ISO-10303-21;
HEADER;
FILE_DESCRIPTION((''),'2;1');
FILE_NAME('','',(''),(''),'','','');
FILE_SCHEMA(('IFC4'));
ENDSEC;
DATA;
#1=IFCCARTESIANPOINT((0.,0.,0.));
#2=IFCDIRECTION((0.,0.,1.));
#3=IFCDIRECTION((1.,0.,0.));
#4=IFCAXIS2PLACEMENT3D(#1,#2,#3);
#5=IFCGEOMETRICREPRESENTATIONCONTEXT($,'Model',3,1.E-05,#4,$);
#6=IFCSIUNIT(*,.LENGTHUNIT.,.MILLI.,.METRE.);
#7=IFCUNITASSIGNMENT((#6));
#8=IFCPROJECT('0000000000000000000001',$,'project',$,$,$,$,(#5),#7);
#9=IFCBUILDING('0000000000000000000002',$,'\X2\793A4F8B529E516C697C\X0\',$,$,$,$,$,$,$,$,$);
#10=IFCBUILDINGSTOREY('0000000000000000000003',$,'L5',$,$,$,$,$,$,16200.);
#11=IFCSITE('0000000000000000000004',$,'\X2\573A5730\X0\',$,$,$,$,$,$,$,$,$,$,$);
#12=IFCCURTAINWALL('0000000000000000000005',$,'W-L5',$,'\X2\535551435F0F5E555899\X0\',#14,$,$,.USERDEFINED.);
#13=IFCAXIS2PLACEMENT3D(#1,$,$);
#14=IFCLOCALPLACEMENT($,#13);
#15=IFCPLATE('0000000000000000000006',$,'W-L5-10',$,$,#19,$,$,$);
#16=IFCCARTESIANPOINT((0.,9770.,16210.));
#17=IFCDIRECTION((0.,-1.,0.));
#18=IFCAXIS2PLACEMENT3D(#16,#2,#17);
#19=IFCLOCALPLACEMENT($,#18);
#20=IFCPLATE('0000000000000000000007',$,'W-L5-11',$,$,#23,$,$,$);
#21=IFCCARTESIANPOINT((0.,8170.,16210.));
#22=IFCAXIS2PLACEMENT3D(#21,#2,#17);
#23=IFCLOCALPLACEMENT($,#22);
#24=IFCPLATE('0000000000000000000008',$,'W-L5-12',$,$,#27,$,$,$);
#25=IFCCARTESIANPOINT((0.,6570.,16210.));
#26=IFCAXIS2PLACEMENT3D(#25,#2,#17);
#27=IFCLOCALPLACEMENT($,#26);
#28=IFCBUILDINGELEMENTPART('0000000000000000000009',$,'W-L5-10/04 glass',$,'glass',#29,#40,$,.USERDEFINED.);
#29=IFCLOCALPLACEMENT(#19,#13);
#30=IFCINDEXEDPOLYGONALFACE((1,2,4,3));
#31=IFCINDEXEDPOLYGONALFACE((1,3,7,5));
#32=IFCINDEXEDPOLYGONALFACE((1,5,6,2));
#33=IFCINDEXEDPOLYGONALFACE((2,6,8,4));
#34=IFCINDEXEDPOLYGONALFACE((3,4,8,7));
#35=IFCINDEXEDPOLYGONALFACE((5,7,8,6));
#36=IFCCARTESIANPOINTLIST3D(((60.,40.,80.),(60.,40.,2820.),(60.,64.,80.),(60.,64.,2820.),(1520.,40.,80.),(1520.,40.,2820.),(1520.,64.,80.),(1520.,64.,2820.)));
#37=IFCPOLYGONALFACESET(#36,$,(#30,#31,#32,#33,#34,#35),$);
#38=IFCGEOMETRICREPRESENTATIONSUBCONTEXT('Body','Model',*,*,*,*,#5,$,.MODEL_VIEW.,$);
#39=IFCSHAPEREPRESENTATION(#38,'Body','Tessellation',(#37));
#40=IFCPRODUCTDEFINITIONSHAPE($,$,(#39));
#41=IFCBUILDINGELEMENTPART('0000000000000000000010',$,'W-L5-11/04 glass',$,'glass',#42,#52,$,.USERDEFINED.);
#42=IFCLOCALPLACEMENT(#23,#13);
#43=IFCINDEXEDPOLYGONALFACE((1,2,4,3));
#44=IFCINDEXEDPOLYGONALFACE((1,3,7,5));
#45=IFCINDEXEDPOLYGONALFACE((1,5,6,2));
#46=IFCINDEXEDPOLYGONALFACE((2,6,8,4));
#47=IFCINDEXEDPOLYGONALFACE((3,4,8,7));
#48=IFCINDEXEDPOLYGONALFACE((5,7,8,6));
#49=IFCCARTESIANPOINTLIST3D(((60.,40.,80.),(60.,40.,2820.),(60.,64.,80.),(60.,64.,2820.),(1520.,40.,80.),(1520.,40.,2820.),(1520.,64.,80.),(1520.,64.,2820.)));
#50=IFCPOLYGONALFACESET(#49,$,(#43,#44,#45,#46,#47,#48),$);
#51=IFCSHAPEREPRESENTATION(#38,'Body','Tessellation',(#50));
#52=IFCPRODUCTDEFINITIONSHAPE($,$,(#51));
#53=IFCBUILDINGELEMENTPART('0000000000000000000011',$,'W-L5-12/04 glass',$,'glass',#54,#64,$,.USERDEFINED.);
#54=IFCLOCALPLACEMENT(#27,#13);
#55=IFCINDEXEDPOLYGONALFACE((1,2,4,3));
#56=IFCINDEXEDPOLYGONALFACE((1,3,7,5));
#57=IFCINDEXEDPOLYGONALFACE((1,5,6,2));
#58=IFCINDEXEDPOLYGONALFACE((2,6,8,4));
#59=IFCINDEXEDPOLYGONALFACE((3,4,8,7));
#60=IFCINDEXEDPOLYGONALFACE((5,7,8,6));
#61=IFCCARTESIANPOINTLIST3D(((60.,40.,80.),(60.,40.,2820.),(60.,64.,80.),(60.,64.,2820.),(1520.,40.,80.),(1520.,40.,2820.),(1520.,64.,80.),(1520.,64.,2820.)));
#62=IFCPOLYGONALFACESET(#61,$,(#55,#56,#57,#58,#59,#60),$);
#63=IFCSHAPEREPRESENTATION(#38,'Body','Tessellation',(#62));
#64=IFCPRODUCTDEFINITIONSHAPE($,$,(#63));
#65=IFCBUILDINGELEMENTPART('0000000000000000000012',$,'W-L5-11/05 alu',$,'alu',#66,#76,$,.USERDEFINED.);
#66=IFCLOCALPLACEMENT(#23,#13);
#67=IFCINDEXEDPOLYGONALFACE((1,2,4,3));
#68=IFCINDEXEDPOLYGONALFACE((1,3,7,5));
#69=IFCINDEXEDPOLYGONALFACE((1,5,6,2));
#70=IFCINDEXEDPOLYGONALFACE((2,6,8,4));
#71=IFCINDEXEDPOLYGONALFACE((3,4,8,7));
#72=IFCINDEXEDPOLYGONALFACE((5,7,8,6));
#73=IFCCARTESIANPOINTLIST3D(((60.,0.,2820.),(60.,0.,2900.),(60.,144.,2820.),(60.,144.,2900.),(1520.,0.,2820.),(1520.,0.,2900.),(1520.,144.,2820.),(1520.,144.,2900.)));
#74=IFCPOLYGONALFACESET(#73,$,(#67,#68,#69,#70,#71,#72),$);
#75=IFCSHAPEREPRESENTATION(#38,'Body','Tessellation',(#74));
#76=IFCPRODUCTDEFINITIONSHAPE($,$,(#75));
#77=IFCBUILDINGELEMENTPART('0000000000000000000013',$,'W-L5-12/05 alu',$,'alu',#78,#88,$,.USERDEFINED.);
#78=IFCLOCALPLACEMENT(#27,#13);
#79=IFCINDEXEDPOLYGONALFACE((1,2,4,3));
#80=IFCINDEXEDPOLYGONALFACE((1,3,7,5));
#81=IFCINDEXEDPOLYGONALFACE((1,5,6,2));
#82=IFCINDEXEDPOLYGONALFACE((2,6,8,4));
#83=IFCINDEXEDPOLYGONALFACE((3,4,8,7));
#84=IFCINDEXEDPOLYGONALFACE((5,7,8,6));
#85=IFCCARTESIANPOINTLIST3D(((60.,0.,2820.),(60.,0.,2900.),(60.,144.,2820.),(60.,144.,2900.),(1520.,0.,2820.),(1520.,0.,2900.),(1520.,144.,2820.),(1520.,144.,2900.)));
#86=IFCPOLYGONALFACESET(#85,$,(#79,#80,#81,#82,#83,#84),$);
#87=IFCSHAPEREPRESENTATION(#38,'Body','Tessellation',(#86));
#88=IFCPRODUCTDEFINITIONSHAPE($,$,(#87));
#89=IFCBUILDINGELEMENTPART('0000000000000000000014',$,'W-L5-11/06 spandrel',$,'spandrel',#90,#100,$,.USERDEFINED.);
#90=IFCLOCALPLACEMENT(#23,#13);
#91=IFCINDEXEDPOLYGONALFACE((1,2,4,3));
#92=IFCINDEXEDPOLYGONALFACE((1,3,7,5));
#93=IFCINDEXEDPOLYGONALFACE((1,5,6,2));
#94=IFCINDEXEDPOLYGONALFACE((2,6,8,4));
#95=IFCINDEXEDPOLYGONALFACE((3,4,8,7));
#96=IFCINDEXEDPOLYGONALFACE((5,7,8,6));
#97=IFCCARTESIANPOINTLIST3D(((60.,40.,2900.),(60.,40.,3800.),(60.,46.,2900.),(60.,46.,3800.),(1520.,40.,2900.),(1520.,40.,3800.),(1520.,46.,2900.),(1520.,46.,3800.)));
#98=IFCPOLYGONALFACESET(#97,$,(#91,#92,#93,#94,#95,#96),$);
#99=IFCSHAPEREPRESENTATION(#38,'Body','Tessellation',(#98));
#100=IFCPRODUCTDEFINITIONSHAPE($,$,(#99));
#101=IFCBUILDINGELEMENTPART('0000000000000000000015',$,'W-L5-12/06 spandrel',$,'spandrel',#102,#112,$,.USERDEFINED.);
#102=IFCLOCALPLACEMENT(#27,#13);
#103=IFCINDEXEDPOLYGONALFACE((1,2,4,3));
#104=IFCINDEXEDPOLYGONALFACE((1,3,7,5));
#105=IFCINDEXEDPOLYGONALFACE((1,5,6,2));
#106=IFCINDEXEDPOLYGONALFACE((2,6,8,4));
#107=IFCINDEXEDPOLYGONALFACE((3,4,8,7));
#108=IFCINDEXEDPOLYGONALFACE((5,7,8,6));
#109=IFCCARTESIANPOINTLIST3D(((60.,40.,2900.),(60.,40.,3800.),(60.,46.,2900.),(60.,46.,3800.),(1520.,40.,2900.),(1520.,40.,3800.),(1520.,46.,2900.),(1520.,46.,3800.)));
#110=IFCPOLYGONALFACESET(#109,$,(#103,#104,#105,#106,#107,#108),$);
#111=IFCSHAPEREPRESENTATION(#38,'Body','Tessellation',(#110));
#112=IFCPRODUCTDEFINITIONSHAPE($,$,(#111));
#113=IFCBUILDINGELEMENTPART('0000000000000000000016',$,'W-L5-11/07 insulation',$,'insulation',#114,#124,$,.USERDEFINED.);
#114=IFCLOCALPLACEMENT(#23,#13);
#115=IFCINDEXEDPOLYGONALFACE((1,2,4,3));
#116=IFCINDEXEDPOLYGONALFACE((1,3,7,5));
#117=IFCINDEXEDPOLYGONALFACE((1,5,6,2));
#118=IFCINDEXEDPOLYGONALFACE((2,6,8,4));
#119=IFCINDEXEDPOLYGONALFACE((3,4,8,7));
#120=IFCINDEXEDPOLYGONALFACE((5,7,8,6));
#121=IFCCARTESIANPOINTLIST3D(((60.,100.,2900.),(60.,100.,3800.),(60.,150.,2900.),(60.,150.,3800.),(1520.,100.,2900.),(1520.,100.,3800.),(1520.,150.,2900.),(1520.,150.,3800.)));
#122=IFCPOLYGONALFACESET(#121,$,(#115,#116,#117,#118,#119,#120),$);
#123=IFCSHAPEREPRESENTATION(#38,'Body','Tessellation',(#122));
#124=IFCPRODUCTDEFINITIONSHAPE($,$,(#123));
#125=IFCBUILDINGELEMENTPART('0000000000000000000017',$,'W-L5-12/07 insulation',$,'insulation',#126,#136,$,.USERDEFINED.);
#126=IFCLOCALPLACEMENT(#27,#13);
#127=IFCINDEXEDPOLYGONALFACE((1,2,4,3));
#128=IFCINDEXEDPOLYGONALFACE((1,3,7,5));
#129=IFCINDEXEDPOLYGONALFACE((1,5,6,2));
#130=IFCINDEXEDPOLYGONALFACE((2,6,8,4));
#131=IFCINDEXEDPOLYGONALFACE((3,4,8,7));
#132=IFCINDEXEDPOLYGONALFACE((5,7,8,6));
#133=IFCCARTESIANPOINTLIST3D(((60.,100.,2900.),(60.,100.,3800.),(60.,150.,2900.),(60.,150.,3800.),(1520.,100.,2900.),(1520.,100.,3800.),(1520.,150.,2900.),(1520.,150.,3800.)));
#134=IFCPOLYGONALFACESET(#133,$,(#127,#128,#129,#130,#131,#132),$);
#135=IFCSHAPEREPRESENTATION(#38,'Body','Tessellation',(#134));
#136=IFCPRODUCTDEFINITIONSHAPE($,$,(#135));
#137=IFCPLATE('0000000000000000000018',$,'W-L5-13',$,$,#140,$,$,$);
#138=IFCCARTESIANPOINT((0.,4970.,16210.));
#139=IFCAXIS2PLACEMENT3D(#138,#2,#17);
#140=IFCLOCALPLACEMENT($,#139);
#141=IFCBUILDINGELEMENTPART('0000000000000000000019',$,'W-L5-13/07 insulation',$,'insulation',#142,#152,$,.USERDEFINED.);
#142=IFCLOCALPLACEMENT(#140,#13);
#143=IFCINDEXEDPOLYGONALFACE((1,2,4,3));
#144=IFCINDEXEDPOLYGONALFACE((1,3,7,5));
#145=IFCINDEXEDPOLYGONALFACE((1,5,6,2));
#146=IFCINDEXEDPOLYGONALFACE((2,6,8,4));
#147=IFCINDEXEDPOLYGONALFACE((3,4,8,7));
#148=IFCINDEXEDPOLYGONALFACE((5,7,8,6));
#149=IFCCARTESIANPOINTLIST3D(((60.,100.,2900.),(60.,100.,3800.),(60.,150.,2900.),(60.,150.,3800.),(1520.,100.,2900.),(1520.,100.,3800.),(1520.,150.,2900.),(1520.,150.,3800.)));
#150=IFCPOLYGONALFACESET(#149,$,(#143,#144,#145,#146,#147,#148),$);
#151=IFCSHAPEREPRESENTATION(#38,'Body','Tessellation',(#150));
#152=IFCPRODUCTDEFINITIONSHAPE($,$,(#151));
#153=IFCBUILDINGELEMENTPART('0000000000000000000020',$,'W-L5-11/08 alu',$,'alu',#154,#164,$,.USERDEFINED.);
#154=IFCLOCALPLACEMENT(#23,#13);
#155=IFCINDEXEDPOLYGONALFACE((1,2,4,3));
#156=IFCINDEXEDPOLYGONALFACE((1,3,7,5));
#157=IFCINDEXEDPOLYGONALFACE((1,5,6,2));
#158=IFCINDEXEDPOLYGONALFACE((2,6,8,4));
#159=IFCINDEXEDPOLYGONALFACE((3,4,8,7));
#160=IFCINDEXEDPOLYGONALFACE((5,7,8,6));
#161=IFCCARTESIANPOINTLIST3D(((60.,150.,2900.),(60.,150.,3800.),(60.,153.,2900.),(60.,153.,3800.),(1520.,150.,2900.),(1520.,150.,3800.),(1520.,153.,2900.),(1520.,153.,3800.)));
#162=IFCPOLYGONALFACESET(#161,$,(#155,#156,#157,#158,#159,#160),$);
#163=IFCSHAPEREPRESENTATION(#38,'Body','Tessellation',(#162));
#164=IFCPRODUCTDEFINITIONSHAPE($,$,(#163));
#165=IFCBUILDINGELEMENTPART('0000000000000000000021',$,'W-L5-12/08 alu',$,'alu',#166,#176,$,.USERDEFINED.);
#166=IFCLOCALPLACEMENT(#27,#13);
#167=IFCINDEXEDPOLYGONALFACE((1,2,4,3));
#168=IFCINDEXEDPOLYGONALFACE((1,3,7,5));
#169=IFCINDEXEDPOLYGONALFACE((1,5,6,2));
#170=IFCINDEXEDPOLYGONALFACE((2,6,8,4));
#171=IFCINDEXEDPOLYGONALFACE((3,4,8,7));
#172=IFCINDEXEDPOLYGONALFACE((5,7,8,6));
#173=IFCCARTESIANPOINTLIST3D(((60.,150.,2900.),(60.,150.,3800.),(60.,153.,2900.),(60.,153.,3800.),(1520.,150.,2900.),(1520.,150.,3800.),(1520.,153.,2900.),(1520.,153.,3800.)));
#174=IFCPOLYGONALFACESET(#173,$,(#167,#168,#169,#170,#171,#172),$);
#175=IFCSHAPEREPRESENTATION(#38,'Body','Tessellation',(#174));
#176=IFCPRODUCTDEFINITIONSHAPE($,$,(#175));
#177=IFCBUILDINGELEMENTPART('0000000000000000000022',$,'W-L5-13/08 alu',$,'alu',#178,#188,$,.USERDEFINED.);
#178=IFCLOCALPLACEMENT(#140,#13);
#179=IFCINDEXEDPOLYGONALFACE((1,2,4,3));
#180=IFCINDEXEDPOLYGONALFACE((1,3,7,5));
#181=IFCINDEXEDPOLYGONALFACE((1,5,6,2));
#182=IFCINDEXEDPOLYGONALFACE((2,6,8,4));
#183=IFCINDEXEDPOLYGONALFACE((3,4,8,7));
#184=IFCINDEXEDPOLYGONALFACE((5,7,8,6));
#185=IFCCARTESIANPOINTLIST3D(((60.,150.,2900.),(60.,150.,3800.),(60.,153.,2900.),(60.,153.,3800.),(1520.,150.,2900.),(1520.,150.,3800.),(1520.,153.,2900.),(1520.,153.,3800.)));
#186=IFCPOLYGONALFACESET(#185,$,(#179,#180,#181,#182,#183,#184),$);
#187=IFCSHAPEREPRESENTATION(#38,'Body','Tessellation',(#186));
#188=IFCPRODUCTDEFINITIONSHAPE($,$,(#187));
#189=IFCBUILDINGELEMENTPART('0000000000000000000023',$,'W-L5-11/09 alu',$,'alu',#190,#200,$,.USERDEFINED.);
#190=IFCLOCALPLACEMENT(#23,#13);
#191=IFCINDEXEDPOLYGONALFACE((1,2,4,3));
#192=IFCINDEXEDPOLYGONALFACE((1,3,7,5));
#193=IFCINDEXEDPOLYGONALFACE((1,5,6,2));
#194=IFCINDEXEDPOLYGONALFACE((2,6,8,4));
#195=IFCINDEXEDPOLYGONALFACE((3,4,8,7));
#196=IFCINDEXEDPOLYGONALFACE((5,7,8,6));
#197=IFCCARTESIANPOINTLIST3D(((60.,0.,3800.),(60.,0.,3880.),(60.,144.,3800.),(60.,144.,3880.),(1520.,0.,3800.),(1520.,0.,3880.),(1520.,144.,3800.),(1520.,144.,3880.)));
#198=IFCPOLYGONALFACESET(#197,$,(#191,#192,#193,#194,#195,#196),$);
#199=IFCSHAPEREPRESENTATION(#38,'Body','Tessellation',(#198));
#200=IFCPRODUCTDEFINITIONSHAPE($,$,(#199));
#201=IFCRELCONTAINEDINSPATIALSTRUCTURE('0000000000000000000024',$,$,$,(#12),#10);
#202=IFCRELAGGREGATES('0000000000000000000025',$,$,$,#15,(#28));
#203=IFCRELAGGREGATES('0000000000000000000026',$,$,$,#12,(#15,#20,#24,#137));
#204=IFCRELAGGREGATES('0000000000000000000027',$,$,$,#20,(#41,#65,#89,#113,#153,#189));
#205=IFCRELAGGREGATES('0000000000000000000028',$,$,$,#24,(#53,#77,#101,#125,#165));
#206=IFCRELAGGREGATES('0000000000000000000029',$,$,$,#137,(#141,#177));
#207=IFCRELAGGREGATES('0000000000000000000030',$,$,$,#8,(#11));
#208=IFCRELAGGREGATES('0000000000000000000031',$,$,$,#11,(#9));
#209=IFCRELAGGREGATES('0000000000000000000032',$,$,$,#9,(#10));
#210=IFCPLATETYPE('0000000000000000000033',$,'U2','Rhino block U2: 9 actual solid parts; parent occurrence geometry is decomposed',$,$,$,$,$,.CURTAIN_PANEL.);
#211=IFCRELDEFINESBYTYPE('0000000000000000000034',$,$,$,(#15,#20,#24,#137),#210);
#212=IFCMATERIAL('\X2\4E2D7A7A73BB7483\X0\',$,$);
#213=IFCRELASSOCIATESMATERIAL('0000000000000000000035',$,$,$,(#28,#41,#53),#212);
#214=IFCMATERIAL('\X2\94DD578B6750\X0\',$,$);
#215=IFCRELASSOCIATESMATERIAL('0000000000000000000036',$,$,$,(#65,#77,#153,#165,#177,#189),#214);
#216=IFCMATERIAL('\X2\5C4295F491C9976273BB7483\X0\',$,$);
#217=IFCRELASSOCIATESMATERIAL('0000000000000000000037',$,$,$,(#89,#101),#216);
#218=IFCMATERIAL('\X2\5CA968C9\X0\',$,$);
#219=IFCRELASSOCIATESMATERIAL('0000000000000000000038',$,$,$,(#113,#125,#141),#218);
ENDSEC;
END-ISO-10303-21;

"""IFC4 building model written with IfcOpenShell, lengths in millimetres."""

from ifc_helpers import new_model, si_unit, frame, frame_2d, origin, origin_with_axes, place, context, subcontext, project, spatial, rectangle, extrude, source, transform, mapped, material, type_object, element, aggregate, save


model = new_model("IFC4")

# Units and contexts
model_context = context("Model", 3, precision=1e-05, world=origin_with_axes())
body_context = subcontext(model_context, "Body", "Model", "MODEL_VIEW")
ifc_project = project(units=[si_unit("LENGTHUNIT", "METRE", prefix="MILLI")], contexts=[model_context])

# Site, building, storey
site = spatial("IfcSite", under=ifc_project, Name="场地")
building = spatial("IfcBuilding", under=site, Name="示例办公楼")
storey = spatial("IfcBuildingStorey", under=building, Name="L5", Elevation=16200.0)

# Curtain wall, plates, building element parts
curtain_wall = element("IfcCurtainWall", 1, inside=storey, Name="W-L5", ObjectType="单元式幕墙", PredefinedType="USERDEFINED")
plate_type = type_object("IfcPlateType", Name="U2", Description="Rhino block U2: 9 actual solid parts; parent occurrence geometry is decomposed", PredefinedType="CURTAIN_PANEL")
plate_1_placement = place(None, frame((0.0, 9770.0, 16210.0), z_axis=(0.0, 0.0, 1.0), x_axis=(0.0, -1.0, 0.0)))
plate_1 = element("IfcPlate", 2, at=plate_1_placement, type_object=plate_type, Name="W-L5-10")
ifc_material_1 = material(Name="铝型材")
plate_2_placement = place(None, frame((0.0, 8170.0, 16210.0), z_axis=(0.0, 0.0, 1.0), x_axis=(0.0, -1.0, 0.0)))
plate_2 = element("IfcPlate", 3, at=plate_2_placement, type_object=plate_type, Name="W-L5-11")
plate_3_placement = place(None, frame((0.0, 6570.0, 16210.0), z_axis=(0.0, 0.0, 1.0), x_axis=(0.0, -1.0, 0.0)))
plate_3 = element("IfcPlate", 4, at=plate_3_placement, type_object=plate_type, Name="W-L5-12")
ifc_material_2 = material(Name="中空玻璃")
shared_shape_1 = source(origin(), body_context, "Body", "SweptSolid", [
    extrude(rectangle(XDim=1460.0, YDim=24.0, at=frame_2d((790.0, 52.0))), frame((0.0, 0.0, 80.0)), (0.0, 0.0, 1.0), 2740.0),
])
building_element_part_1_placement = place(plate_1_placement, origin())
building_element_part_1 = element("IfcBuildingElementPart", 5, at=building_element_part_1_placement, material=ifc_material_2, Name="W-L5-10/04 glass", ObjectType="glass", PredefinedType="USERDEFINED", context=body_context, shape_type="MappedRepresentation", body=[
    mapped(shared_shape_1, transform((0.0, 0.0, 0.0))),
])
aggregate(plate_1, [building_element_part_1])
building_element_part_2_placement = place(plate_2_placement, origin())
building_element_part_2 = element("IfcBuildingElementPart", 6, at=building_element_part_2_placement, material=ifc_material_2, Name="W-L5-11/04 glass", ObjectType="glass", PredefinedType="USERDEFINED", context=body_context, shape_type="MappedRepresentation", body=[
    mapped(shared_shape_1, transform((0.0, 0.0, 0.0))),
])
building_element_part_3_placement = place(plate_3_placement, origin())
building_element_part_3 = element("IfcBuildingElementPart", 7, at=building_element_part_3_placement, material=ifc_material_2, Name="W-L5-12/04 glass", ObjectType="glass", PredefinedType="USERDEFINED", context=body_context, shape_type="MappedRepresentation", body=[
    mapped(shared_shape_1, transform((0.0, 0.0, 0.0))),
])
shared_shape_2 = source(origin(), body_context, "Body", "SweptSolid", [
    extrude(rectangle(XDim=1460.0, YDim=144.0, at=frame_2d((790.0, 72.0))), frame((0.0, 0.0, 2820.0)), (0.0, 0.0, 1.0), 80.0),
])
building_element_part_4_placement = place(plate_2_placement, origin())
building_element_part_4 = element("IfcBuildingElementPart", 8, at=building_element_part_4_placement, material=ifc_material_1, Name="W-L5-11/05 alu", ObjectType="alu", PredefinedType="USERDEFINED", context=body_context, shape_type="MappedRepresentation", body=[
    mapped(shared_shape_2, transform((0.0, 0.0, 0.0))),
])
building_element_part_5_placement = place(plate_3_placement, origin())
building_element_part_5 = element("IfcBuildingElementPart", 9, at=building_element_part_5_placement, material=ifc_material_1, Name="W-L5-12/05 alu", ObjectType="alu", PredefinedType="USERDEFINED", context=body_context, shape_type="MappedRepresentation", body=[
    mapped(shared_shape_2, transform((0.0, 0.0, 0.0))),
])
ifc_material_3 = material(Name="层间釉面玻璃")
shared_shape_3 = source(origin(), body_context, "Body", "SweptSolid", [
    extrude(rectangle(XDim=1460.0, YDim=6.0, at=frame_2d((790.0, 43.0))), frame((0.0, 0.0, 2900.0)), (0.0, 0.0, 1.0), 900.0),
])
building_element_part_6_placement = place(plate_2_placement, origin())
building_element_part_6 = element("IfcBuildingElementPart", 10, at=building_element_part_6_placement, material=ifc_material_3, Name="W-L5-11/06 spandrel", ObjectType="spandrel", PredefinedType="USERDEFINED", context=body_context, shape_type="MappedRepresentation", body=[
    mapped(shared_shape_3, transform((0.0, 0.0, 0.0))),
])
building_element_part_7_placement = place(plate_3_placement, origin())
building_element_part_7 = element("IfcBuildingElementPart", 11, at=building_element_part_7_placement, material=ifc_material_3, Name="W-L5-12/06 spandrel", ObjectType="spandrel", PredefinedType="USERDEFINED", context=body_context, shape_type="MappedRepresentation", body=[
    mapped(shared_shape_3, transform((0.0, 0.0, 0.0))),
])
ifc_material_4 = material(Name="岩棉")
shared_shape_4 = source(origin(), body_context, "Body", "SweptSolid", [
    extrude(rectangle(XDim=1460.0, YDim=50.0, at=frame_2d((790.0, 125.0))), frame((0.0, 0.0, 2900.0)), (0.0, 0.0, 1.0), 900.0),
])
building_element_part_8_placement = place(plate_2_placement, origin())
building_element_part_8 = element("IfcBuildingElementPart", 12, at=building_element_part_8_placement, material=ifc_material_4, Name="W-L5-11/07 insulation", ObjectType="insulation", PredefinedType="USERDEFINED", context=body_context, shape_type="MappedRepresentation", body=[
    mapped(shared_shape_4, transform((0.0, 0.0, 0.0))),
])
building_element_part_9_placement = place(plate_3_placement, origin())
building_element_part_9 = element("IfcBuildingElementPart", 13, at=building_element_part_9_placement, material=ifc_material_4, Name="W-L5-12/07 insulation", ObjectType="insulation", PredefinedType="USERDEFINED", context=body_context, shape_type="MappedRepresentation", body=[
    mapped(shared_shape_4, transform((0.0, 0.0, 0.0))),
])
plate_4_placement = place(None, frame((0.0, 4970.0, 16210.0), z_axis=(0.0, 0.0, 1.0), x_axis=(0.0, -1.0, 0.0)))
plate_4 = element("IfcPlate", 14, at=plate_4_placement, type_object=plate_type, Name="W-L5-13")
aggregate(curtain_wall, [plate_1, plate_2, plate_3, plate_4])
building_element_part_10_placement = place(plate_4_placement, origin())
building_element_part_10 = element("IfcBuildingElementPart", 15, at=building_element_part_10_placement, material=ifc_material_4, Name="W-L5-13/07 insulation", ObjectType="insulation", PredefinedType="USERDEFINED", context=body_context, shape_type="MappedRepresentation", body=[
    mapped(shared_shape_4, transform((0.0, 0.0, 0.0))),
])
shared_shape_5 = source(origin(), body_context, "Body", "SweptSolid", [
    extrude(rectangle(XDim=1460.0, YDim=3.0, at=frame_2d((790.0, 151.5))), frame((0.0, 0.0, 2900.0)), (0.0, 0.0, 1.0), 900.0),
])
building_element_part_11_placement = place(plate_2_placement, origin())
building_element_part_11 = element("IfcBuildingElementPart", 16, at=building_element_part_11_placement, material=ifc_material_1, Name="W-L5-11/08 alu", ObjectType="alu", PredefinedType="USERDEFINED", context=body_context, shape_type="MappedRepresentation", body=[
    mapped(shared_shape_5, transform((0.0, 0.0, 0.0))),
])
building_element_part_12_placement = place(plate_3_placement, origin())
building_element_part_12 = element("IfcBuildingElementPart", 17, at=building_element_part_12_placement, material=ifc_material_1, Name="W-L5-12/08 alu", ObjectType="alu", PredefinedType="USERDEFINED", context=body_context, shape_type="MappedRepresentation", body=[
    mapped(shared_shape_5, transform((0.0, 0.0, 0.0))),
])
building_element_part_13_placement = place(plate_4_placement, origin())
building_element_part_13 = element("IfcBuildingElementPart", 18, at=building_element_part_13_placement, material=ifc_material_1, Name="W-L5-13/08 alu", ObjectType="alu", PredefinedType="USERDEFINED", context=body_context, shape_type="MappedRepresentation", body=[
    mapped(shared_shape_5, transform((0.0, 0.0, 0.0))),
])
shared_shape_6 = source(origin(), body_context, "Body", "SweptSolid", [
    extrude(rectangle(XDim=1460.0, YDim=144.0, at=frame_2d((790.0, 72.0))), frame((0.0, 0.0, 3800.0)), (0.0, 0.0, 1.0), 80.0),
])
building_element_part_14_placement = place(plate_2_placement, origin())
building_element_part_14 = element("IfcBuildingElementPart", 19, at=building_element_part_14_placement, material=ifc_material_1, Name="W-L5-11/09 alu", ObjectType="alu", PredefinedType="USERDEFINED", context=body_context, shape_type="MappedRepresentation", body=[
    mapped(shared_shape_6, transform((0.0, 0.0, 0.0))),
])
aggregate(plate_2, [building_element_part_2, building_element_part_4, building_element_part_6, building_element_part_8, building_element_part_11, building_element_part_14])
aggregate(plate_3, [building_element_part_3, building_element_part_5, building_element_part_7, building_element_part_9, building_element_part_12])
aggregate(plate_4, [building_element_part_10, building_element_part_13])

save(model, "model.ifc")
